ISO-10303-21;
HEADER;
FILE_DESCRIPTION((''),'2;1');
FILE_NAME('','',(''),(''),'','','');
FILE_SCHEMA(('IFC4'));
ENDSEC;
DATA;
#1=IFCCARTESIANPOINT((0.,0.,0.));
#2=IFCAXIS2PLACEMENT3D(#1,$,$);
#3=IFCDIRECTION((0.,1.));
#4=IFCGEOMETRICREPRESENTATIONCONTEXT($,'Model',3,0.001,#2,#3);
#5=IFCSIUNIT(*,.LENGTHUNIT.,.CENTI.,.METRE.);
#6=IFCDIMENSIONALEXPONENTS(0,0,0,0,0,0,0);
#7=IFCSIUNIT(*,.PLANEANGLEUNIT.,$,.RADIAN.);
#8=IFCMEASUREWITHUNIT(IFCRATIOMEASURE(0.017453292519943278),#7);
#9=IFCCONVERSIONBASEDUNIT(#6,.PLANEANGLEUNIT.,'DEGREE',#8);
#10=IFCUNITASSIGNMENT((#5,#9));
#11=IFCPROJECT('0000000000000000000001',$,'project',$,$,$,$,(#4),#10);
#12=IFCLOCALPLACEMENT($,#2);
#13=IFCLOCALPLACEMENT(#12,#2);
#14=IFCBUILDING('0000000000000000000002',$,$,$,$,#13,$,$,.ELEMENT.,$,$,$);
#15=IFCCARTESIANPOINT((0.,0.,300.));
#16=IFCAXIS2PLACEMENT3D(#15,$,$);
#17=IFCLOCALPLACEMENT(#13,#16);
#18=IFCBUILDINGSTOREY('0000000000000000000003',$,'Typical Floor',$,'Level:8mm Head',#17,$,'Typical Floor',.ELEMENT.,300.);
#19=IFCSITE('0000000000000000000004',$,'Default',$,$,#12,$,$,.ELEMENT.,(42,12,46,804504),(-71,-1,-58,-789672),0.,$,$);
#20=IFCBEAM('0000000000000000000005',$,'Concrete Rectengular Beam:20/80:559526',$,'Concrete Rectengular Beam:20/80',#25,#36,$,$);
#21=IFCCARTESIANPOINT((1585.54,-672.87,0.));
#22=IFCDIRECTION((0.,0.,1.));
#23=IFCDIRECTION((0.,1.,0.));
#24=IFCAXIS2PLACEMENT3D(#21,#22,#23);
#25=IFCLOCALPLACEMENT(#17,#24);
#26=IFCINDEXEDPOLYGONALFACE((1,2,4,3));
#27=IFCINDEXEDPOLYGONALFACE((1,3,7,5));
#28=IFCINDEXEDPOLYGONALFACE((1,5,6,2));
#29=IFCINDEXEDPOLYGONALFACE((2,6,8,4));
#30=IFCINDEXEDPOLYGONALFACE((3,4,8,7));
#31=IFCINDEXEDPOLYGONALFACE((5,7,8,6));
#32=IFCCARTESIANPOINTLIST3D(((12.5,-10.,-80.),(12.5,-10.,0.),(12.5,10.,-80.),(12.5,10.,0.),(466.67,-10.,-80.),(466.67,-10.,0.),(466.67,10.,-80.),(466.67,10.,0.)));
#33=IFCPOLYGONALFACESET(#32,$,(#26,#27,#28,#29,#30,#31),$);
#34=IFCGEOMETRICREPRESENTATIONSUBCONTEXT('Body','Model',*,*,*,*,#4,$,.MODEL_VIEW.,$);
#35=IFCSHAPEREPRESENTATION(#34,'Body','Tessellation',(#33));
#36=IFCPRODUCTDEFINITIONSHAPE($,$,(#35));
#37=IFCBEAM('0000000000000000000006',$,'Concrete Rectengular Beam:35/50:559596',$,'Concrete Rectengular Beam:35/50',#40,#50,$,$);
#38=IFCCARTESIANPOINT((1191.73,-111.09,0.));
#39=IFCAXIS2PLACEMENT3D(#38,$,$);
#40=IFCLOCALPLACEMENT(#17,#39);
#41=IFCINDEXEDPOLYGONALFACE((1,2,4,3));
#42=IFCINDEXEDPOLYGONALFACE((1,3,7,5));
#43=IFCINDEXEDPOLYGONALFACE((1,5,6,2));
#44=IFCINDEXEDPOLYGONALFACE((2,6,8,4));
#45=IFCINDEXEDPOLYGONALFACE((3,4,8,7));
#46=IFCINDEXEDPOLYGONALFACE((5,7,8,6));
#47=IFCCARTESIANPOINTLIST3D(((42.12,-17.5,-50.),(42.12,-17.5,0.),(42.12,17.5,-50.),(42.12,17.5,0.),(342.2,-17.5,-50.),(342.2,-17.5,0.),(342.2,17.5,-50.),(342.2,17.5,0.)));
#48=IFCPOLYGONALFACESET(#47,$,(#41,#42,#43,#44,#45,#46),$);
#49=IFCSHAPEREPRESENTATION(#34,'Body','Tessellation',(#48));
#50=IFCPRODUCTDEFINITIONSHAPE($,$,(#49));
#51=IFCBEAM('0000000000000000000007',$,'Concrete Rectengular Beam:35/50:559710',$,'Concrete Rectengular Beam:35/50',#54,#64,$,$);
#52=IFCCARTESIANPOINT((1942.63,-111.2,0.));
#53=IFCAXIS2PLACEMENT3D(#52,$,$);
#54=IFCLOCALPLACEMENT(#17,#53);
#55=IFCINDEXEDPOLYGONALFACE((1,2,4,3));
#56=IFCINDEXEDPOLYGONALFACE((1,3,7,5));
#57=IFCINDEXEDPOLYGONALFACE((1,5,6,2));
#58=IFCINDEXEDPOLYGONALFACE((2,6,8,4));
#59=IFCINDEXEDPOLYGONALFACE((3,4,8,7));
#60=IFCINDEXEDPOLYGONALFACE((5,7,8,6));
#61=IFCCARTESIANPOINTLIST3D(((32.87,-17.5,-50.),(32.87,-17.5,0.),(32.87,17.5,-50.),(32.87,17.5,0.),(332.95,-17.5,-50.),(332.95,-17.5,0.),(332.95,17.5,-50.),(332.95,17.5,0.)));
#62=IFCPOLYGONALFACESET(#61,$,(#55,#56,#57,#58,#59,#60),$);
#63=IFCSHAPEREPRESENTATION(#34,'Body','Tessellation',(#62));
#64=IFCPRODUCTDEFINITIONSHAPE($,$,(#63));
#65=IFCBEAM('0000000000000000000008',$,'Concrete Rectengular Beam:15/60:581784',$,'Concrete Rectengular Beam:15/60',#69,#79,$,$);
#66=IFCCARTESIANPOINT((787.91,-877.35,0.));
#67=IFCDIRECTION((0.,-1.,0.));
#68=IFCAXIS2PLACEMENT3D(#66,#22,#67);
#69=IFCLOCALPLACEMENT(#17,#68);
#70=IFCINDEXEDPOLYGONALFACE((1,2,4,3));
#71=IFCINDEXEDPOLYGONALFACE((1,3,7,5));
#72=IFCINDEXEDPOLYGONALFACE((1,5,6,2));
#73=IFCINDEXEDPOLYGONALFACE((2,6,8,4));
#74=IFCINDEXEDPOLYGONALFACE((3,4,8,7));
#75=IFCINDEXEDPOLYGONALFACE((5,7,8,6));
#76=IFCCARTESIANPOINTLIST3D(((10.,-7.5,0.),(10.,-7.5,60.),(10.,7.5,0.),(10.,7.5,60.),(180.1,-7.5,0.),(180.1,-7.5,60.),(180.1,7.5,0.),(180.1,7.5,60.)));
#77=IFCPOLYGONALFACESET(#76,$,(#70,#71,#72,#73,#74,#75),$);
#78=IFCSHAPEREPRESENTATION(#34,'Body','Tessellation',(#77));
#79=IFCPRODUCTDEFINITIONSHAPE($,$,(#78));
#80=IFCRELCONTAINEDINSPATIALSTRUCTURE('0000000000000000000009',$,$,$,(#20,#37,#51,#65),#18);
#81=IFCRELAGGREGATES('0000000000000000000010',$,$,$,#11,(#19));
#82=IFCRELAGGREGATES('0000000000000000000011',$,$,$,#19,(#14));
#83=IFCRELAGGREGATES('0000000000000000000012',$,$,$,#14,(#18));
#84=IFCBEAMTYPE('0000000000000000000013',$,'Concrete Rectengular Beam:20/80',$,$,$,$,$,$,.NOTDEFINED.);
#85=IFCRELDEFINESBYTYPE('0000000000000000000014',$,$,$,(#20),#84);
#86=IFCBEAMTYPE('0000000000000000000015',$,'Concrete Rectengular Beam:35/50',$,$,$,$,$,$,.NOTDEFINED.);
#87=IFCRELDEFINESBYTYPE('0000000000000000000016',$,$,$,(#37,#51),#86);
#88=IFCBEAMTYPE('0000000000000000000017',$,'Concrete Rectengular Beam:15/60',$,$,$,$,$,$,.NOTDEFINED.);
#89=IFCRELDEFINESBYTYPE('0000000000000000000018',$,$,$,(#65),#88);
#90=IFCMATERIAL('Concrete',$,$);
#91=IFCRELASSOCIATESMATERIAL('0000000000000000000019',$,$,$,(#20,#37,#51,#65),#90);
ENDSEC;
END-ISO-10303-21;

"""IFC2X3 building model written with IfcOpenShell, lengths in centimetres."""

from ifc_helpers import new_model, entity, si_unit, converted_unit, direction, frame, frame_2d, origin, place, context, subcontext, project, spatial, rectangle, extrude, material, type_object, element, save


model = new_model("IFC2X3")

# Units and contexts
model_context = context("Model", 3, precision=0.001, world=origin(), true_north=direction((0.0, 1.0)))
body_context = subcontext(model_context, "Body", "Model", "MODEL_VIEW")
ifc_project = project(units=[si_unit("LENGTHUNIT", "METRE", prefix="CENTI"), converted_unit("PLANEANGLEUNIT", "DEGREE", entity("IfcRatioMeasure", 0.017453292519943278), si_unit("PLANEANGLEUNIT", "RADIAN"), dimensions=[0, 0, 0, 0, 0, 0, 0])], contexts=[model_context])

# Site, building, storey
site_placement = place(None, origin())
site = spatial("IfcSite", under=ifc_project, at=site_placement, Name="Default", CompositionType="ELEMENT", RefLatitude=(42, 12, 46, 804504), RefLongitude=(-71, -1, -58, -789672), RefElevation=0.0)
building_placement = place(site_placement, origin())
building = spatial("IfcBuilding", under=site, at=building_placement, CompositionType="ELEMENT")
storey_placement = place(building_placement, frame((0.0, 0.0, 300.0)))
storey = spatial("IfcBuildingStorey", under=building, at=storey_placement, Name="Typical Floor", ObjectType="Level:8mm Head", LongName="Typical Floor", CompositionType="ELEMENT", Elevation=300.0)

# Beams
ifc_material = material(Name="Concrete")
beam_type_1 = type_object("IfcBeamType", Name="Concrete Rectengular Beam:20/80", PredefinedType="NOTDEFINED")
beam_1_placement = place(storey_placement, frame((1585.54, -672.87, 0.0), z_axis=(0.0, 0.0, 1.0), x_axis=(0.0, 1.0, 0.0)))
element("IfcBeam", 1, at=beam_1_placement, inside=storey, type_object=beam_type_1, material=ifc_material, Name="Concrete Rectengular Beam:20/80:559526", ObjectType="Concrete Rectengular Beam:20/80", context=body_context, shape_type="SweptSolid", body=[
    extrude(rectangle(XDim=80.0, YDim=20.0, at=frame_2d((0.0, 0.0), x_axis=(1.0, 0.0))), frame((12.5, 0.0, -40.0), z_axis=(1.0, 0.0, 0.0), x_axis=(0.0, 0.0, -1.0)), (0.0, 0.0, 1.0), 454.17),
])
beam_type_2 = type_object("IfcBeamType", Name="Concrete Rectengular Beam:35/50", PredefinedType="NOTDEFINED")
beam_2_placement = place(storey_placement, frame((1191.73, -111.09, 0.0)))
element("IfcBeam", 2, at=beam_2_placement, inside=storey, type_object=beam_type_2, material=ifc_material, Name="Concrete Rectengular Beam:35/50:559596", ObjectType="Concrete Rectengular Beam:35/50", context=body_context, shape_type="SweptSolid", body=[
    extrude(rectangle(XDim=50.0, YDim=35.0, at=frame_2d((0.0, 0.0), x_axis=(1.0, 0.0))), frame((42.12, 0.0, -25.0), z_axis=(1.0, 0.0, 0.0), x_axis=(0.0, 0.0, -1.0)), (0.0, 0.0, 1.0), 300.08),
])
beam_3_placement = place(storey_placement, frame((1942.63, -111.2, 0.0)))
element("IfcBeam", 3, at=beam_3_placement, inside=storey, type_object=beam_type_2, material=ifc_material, Name="Concrete Rectengular Beam:35/50:559710", ObjectType="Concrete Rectengular Beam:35/50", context=body_context, shape_type="SweptSolid", body=[
    extrude(rectangle(XDim=50.0, YDim=35.0, at=frame_2d((0.0, 0.0), x_axis=(1.0, 0.0))), frame((32.87, 0.0, -25.0), z_axis=(1.0, 0.0, 0.0), x_axis=(0.0, 0.0, -1.0)), (0.0, 0.0, 1.0), 300.08),
])
beam_type_3 = type_object("IfcBeamType", Name="Concrete Rectengular Beam:15/60", PredefinedType="NOTDEFINED")
beam_4_placement = place(storey_placement, frame((787.91, -877.35, 0.0), z_axis=(0.0, 0.0, 1.0), x_axis=(0.0, -1.0, 0.0)))
element("IfcBeam", 4, at=beam_4_placement, inside=storey, type_object=beam_type_3, material=ifc_material, Name="Concrete Rectengular Beam:15/60:581784", ObjectType="Concrete Rectengular Beam:15/60", context=body_context, shape_type="SweptSolid", body=[
    extrude(rectangle(XDim=60.0, YDim=15.0, at=frame_2d((0.0, 0.0), x_axis=(1.0, 0.0))), frame((10.0, 0.0, 30.0), z_axis=(1.0, 0.0, 0.0), x_axis=(0.0, 0.0, -1.0)), (0.0, 0.0, 1.0), 170.1),
])

save(model, "model.ifc")
